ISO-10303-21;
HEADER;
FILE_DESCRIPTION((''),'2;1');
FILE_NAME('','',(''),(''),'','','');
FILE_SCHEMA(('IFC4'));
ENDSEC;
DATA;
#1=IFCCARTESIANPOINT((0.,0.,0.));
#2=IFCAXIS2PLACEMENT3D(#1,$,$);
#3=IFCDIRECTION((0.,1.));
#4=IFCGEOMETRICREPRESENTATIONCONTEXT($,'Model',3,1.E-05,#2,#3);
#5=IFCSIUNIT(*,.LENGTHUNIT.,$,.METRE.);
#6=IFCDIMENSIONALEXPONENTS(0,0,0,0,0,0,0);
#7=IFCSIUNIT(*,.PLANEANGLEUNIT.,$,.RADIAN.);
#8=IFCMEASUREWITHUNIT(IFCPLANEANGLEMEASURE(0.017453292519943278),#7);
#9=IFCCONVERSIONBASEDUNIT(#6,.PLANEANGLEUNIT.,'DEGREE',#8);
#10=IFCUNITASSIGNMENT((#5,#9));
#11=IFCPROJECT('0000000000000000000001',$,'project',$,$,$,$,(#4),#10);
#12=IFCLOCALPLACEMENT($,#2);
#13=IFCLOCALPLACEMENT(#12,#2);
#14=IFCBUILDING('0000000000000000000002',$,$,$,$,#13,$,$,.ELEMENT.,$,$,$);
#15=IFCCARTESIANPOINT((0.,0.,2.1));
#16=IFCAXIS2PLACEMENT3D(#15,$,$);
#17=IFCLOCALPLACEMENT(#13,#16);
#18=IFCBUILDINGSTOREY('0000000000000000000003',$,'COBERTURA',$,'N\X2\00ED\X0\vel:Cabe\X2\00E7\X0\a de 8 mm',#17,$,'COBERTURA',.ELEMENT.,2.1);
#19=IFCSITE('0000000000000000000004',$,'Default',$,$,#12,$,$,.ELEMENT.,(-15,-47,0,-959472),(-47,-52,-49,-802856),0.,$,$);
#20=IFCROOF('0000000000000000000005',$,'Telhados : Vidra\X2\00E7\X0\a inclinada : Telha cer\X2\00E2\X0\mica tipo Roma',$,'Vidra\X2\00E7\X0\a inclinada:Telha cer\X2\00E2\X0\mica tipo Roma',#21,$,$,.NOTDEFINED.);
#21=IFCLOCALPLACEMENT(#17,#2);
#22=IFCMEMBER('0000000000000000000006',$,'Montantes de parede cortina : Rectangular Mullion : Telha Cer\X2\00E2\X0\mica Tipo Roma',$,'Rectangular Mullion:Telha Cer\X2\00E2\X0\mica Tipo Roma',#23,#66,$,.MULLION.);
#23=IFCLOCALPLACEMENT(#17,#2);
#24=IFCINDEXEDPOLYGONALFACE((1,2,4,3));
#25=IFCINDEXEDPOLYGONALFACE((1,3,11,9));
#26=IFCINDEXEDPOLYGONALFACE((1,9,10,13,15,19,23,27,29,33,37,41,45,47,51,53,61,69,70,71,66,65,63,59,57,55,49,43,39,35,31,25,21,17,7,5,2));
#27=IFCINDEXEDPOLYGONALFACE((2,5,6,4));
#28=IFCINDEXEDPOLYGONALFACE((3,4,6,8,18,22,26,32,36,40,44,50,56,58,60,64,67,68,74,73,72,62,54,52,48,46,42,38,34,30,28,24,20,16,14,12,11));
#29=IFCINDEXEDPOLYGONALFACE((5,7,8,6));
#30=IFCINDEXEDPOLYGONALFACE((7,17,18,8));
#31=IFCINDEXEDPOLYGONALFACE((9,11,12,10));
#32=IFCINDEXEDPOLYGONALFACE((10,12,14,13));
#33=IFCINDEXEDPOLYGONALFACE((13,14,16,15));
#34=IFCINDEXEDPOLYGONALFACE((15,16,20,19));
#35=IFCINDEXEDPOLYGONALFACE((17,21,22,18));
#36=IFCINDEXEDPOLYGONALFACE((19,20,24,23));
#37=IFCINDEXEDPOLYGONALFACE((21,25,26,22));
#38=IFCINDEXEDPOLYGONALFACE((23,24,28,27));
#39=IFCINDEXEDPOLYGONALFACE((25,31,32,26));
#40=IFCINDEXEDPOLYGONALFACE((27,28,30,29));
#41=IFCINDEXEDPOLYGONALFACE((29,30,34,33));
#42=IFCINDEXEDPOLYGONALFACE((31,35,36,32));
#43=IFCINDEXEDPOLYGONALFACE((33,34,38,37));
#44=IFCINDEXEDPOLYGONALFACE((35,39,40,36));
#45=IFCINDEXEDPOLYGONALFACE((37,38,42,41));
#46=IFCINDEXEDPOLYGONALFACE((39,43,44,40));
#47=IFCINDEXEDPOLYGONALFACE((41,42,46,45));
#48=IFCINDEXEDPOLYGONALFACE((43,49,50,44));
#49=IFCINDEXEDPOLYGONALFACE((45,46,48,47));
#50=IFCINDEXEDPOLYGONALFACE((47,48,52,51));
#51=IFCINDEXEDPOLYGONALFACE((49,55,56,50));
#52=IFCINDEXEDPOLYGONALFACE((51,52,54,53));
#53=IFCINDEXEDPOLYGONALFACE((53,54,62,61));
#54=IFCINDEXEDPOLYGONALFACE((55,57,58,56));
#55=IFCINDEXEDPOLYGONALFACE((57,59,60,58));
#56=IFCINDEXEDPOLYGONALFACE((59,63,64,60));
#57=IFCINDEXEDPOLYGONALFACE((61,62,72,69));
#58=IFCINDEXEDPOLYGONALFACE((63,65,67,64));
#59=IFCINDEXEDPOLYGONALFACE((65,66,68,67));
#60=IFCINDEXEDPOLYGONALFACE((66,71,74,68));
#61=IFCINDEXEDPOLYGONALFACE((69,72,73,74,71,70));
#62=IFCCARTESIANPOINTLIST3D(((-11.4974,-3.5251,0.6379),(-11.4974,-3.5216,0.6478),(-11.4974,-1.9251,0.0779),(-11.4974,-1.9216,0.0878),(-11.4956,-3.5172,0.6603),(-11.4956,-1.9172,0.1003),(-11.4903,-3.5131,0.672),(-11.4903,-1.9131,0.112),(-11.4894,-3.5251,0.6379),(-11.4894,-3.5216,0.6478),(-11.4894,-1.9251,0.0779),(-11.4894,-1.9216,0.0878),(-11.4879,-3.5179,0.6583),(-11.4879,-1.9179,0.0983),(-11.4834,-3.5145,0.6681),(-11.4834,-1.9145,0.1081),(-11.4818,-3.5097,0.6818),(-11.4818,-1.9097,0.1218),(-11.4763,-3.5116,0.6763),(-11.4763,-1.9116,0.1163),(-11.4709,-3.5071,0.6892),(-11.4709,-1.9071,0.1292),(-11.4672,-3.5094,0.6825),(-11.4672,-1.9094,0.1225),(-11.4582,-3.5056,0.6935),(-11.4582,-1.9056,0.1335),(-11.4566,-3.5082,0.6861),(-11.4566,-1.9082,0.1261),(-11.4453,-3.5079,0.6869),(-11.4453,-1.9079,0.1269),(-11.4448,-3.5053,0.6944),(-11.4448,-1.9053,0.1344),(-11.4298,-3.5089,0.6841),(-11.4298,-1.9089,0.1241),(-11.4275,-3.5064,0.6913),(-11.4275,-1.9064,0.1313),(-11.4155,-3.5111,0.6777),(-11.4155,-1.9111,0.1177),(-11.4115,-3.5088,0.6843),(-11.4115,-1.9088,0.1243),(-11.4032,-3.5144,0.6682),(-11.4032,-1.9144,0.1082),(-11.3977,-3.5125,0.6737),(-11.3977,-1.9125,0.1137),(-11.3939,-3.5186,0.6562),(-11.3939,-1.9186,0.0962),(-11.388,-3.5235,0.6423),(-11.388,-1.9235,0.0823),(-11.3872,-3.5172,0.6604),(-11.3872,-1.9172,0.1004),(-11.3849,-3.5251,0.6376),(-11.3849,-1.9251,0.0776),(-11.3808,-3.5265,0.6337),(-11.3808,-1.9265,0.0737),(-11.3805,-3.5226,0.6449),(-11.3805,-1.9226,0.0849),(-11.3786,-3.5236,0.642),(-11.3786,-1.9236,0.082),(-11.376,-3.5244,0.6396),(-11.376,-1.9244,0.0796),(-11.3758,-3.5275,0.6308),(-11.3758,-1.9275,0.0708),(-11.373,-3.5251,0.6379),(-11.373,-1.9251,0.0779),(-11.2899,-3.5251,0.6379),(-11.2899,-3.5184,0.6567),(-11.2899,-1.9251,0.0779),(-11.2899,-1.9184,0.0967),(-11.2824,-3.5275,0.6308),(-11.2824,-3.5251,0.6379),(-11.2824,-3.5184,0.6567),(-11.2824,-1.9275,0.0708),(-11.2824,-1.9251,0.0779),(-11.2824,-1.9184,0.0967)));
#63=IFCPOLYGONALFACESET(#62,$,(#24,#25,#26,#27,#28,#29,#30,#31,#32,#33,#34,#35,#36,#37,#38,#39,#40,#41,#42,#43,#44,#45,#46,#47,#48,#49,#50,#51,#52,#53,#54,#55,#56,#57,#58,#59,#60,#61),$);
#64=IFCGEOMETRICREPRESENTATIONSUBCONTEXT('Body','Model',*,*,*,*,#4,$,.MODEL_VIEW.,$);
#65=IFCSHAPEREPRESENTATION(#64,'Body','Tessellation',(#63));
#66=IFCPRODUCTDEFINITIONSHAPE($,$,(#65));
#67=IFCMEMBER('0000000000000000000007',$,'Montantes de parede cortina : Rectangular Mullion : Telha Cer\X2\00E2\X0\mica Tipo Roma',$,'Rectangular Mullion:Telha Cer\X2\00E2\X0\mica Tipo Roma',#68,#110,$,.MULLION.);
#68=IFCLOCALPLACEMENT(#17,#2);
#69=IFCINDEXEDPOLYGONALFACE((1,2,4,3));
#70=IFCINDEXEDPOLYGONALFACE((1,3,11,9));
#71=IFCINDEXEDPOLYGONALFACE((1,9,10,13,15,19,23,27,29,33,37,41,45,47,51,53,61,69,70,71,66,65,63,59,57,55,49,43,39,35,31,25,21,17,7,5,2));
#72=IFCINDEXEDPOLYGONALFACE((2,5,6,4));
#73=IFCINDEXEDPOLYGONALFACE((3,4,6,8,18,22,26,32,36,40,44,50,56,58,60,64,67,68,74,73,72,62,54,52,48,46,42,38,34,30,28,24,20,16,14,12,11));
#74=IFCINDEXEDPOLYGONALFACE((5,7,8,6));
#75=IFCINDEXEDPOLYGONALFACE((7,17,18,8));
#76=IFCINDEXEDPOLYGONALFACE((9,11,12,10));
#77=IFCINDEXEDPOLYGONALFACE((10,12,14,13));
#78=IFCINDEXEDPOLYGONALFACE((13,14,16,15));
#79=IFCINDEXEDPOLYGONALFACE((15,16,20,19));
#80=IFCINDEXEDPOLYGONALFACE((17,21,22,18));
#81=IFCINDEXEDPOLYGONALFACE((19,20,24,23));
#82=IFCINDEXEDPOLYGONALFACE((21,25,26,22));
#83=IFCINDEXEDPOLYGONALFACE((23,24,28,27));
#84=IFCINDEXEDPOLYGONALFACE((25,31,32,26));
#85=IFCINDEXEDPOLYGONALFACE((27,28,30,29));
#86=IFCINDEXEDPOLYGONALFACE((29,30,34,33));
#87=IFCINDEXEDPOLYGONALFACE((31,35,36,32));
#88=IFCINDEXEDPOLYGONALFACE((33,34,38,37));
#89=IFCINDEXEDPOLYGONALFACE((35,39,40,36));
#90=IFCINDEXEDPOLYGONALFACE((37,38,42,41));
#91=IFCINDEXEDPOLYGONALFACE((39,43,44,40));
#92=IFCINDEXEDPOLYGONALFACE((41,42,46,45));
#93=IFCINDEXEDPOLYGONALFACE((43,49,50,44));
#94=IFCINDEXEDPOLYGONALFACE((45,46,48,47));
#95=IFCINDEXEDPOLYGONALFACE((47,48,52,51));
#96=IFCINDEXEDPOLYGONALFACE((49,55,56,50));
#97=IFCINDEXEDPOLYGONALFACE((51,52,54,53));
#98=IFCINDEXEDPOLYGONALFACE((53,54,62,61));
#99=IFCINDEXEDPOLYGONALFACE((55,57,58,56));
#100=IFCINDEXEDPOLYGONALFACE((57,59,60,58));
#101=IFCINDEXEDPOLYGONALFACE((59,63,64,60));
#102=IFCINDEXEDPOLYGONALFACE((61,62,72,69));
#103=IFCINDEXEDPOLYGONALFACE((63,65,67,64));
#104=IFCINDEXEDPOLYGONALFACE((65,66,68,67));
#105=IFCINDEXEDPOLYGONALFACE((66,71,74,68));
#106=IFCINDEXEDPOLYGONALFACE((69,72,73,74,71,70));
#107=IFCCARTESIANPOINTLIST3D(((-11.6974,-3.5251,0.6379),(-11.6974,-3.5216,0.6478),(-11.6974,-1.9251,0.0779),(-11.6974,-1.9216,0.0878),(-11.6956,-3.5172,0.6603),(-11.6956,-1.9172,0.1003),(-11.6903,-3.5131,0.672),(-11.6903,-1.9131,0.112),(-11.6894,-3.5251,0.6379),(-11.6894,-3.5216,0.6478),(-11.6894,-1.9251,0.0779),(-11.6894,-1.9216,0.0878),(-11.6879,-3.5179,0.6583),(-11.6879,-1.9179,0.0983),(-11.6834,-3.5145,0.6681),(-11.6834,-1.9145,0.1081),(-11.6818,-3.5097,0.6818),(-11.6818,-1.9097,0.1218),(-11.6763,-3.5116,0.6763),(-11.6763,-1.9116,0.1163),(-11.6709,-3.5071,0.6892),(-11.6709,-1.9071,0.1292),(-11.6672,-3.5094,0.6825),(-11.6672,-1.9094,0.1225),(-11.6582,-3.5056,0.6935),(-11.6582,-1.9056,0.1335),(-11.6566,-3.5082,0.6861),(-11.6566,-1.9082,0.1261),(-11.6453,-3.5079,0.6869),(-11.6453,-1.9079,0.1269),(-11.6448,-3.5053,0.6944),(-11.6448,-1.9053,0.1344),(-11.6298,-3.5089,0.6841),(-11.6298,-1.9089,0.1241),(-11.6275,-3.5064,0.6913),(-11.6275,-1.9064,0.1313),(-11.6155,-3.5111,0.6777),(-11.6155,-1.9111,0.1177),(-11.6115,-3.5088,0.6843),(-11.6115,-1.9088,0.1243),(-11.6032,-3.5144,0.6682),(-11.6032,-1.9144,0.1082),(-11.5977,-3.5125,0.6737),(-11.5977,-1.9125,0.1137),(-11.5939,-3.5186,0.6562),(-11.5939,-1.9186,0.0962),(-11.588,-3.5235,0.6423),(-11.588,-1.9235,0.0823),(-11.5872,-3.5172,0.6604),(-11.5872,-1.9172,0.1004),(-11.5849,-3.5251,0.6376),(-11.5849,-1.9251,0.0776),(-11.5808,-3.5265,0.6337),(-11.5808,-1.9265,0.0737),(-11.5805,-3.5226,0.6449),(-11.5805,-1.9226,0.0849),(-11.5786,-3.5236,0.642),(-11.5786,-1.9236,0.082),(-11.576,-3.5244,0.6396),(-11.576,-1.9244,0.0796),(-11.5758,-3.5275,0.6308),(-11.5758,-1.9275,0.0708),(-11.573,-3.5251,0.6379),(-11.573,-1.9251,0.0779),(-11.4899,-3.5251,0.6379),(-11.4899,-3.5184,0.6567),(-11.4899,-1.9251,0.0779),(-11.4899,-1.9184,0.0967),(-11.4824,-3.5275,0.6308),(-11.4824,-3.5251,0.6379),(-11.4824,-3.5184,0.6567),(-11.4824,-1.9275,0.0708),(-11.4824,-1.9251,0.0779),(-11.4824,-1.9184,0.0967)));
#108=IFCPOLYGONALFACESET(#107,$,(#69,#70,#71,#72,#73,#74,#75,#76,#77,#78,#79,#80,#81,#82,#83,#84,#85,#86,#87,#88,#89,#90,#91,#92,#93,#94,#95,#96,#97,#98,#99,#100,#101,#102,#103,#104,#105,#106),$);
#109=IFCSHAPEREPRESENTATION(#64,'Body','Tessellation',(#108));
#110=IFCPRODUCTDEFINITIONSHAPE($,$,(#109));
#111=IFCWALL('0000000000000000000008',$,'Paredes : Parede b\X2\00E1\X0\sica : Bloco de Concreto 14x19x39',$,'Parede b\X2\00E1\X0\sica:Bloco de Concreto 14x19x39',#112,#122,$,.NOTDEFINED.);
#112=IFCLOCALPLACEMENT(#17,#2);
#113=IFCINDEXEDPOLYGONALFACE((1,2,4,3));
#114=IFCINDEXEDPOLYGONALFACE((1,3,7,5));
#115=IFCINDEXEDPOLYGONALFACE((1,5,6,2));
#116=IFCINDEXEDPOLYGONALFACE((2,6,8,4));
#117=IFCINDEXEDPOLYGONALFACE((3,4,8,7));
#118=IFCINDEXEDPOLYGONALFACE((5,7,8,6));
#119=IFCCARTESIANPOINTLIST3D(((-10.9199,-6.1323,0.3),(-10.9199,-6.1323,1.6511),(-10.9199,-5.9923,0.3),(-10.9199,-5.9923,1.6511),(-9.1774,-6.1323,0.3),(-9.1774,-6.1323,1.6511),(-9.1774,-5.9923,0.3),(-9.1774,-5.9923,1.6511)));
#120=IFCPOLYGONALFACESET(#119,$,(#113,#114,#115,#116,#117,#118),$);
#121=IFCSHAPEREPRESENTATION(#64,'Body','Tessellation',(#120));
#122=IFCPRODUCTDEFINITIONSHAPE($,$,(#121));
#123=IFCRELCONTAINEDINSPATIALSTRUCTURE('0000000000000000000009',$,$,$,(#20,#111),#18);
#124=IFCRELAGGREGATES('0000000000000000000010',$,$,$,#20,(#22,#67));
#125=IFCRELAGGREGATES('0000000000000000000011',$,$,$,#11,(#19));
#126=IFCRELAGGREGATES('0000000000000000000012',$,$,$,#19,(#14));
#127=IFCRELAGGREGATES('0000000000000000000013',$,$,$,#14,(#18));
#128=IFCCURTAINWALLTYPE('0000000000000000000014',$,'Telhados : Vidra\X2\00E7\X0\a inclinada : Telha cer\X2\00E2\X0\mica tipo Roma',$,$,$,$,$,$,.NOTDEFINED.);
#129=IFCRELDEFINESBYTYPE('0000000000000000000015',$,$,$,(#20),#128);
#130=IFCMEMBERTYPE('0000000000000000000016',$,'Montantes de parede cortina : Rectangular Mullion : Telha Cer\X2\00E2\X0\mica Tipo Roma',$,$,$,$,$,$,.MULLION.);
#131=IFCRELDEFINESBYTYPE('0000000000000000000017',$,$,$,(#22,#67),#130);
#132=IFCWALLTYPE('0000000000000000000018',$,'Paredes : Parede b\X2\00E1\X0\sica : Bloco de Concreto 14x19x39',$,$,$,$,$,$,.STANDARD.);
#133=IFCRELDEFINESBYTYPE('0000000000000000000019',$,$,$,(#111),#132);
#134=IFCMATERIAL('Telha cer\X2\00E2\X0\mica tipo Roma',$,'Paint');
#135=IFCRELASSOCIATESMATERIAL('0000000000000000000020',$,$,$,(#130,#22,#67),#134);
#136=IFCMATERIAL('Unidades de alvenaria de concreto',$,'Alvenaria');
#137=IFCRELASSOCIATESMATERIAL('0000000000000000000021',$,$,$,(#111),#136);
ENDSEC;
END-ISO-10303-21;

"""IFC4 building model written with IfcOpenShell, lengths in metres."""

from ifc_helpers import new_model, entity, si_unit, converted_unit, direction, frame, origin, place, context, subcontext, project, spatial, line, arc, indexed_curve, outline, extrude, source, transform, mapped, material, type_object, type_shapes, element, aggregate, save


model = new_model("IFC4")

# Units and contexts
model_context = context("Model", 3, precision=1e-05, world=origin(), true_north=direction((0.0, 1.0)))
body_context = subcontext(model_context, "Body", "Model", "MODEL_VIEW")
ifc_project = project(units=[si_unit("LENGTHUNIT", "METRE"), converted_unit("PLANEANGLEUNIT", "DEGREE", entity("IfcPlaneAngleMeasure", 0.017453292519943278), si_unit("PLANEANGLEUNIT", "RADIAN"), dimensions=[0, 0, 0, 0, 0, 0, 0])], contexts=[model_context])

# Site, building, storey
site_placement = place(None, origin())
site = spatial("IfcSite", under=ifc_project, at=site_placement, Name="Default", CompositionType="ELEMENT", RefLatitude=(-15, -47, 0, -959472), RefLongitude=(-47, -52, -49, -802856), RefElevation=0.0)
building_placement = place(site_placement, origin())
building = spatial("IfcBuilding", under=site, at=building_placement, CompositionType="ELEMENT")
storey_placement = place(building_placement, frame((0.0, 0.0, 2.1)))
storey = spatial("IfcBuildingStorey", under=building, at=storey_placement, Name="COBERTURA", ObjectType="Nível:Cabeça de 8 mm", LongName="COBERTURA", CompositionType="ELEMENT", Elevation=2.1)

# Roof, members
curtain_wall_type_1 = type_object("IfcCurtainWallType", Name="Telhados : Vidraça inclinada : Telha cerâmica tipo Roma", PredefinedType="NOTDEFINED")
roof_1_placement = place(storey_placement, frame((0.0, 0.0, -2.1)))
roof_1 = element("IfcRoof", 1, at=roof_1_placement, inside=storey, type_object=curtain_wall_type_1, Name="Telhados : Vidraça inclinada : Telha cerâmica tipo Roma", ObjectType="Vidraça inclinada:Telha cerâmica tipo Roma", PredefinedType="NOTDEFINED")
ifc_material_1 = material(Name="Telha cerâmica tipo Roma", Category="Paint")
member_type_1 = type_object("IfcMemberType", Name="Montantes de parede cortina : Rectangular Mullion : Telha Cerâmica Tipo Roma", PredefinedType="MULLION", material=ifc_material_1)
shared_shape_1 = source(origin(), body_context, "Body", "SweptSolid", [
    extrude(outline(indexed_curve([(0.0114, -0.0188), (0.1048, -0.0188), (0.1048, -0.0113), (0.1048, 0.0087), (0.0973, 0.0087), (0.0973, -0.0113), (0.0142, -0.0113), (0.0098, -0.0083), (0.0067, -0.0038), (-0.017, 0.0327), (-0.0576, 0.0486), (-0.0946, 0.0352), (-0.1102, -0.0008), (-0.1102, -0.0113), (-0.1022, -0.0113), (-0.1022, -0.0008), (-0.0891, 0.0294), (-0.0581, 0.0406), (-0.0218, 0.0263), (-0.0008, -0.0066), (0.0042, -0.0138)], segments=[line(1, 2, 3, 4, 5, 6, 7), arc(7, 8, 9), arc(9, 10, 11), arc(11, 12, 13), line(13, 14, 15, 16), arc(16, 17, 18), arc(18, 19, 20), arc(20, 21, 1)], self_intersect=False)), frame((-0.0027, -0.0938, -4.3552), z_axis=(0.0, 0.0, 1.0), x_axis=(-1.0, 0.0, 0.0)), (0.0, 0.0, 1.0), 1.6952),
])
type_shapes(member_type_1, [shared_shape_1])
member_1_placement = place(roof_1_placement, frame((-11.3899, -6.063, 3.5387), z_axis=(0.0, -0.943858, 0.33035), x_axis=(-1.0, 0.0, 0.0)))
member_1 = element("IfcMember", 2, at=member_1_placement, type_object=member_type_1, material=ifc_material_1, Name="Montantes de parede cortina : Rectangular Mullion : Telha Cerâmica Tipo Roma", ObjectType="Rectangular Mullion:Telha Cerâmica Tipo Roma", PredefinedType="MULLION", context=body_context, shape_type="MappedRepresentation", body=[
    mapped(shared_shape_1, transform((0.0, 0.0, 0.0), scale=1.0)),
])
member_2_placement = place(roof_1_placement, frame((-11.5899, -6.063, 3.5387), z_axis=(0.0, -0.943858, 0.33035), x_axis=(-1.0, 0.0, 0.0)))
member_2 = element("IfcMember", 3, at=member_2_placement, type_object=member_type_1, material=ifc_material_1, Name="Montantes de parede cortina : Rectangular Mullion : Telha Cerâmica Tipo Roma", ObjectType="Rectangular Mullion:Telha Cerâmica Tipo Roma", PredefinedType="MULLION", context=body_context, shape_type="MappedRepresentation", body=[
    mapped(shared_shape_1, transform((0.0, 0.0, 0.0), scale=1.0)),
])
aggregate(roof_1, [member_1, member_2])

# Wall
ifc_material_2 = material(Name="Unidades de alvenaria de concreto", Category="Alvenaria")
wall_type = type_object("IfcWallType", Name="Paredes : Parede básica : Bloco de Concreto 14x19x39", PredefinedType="STANDARD")
wall_placement = place(storey_placement, frame((-10.9199, -6.0623, 0.3)))
element("IfcWall", 4, at=wall_placement, inside=storey, type_object=wall_type, material=ifc_material_2, Name="Paredes : Parede básica : Bloco de Concreto 14x19x39", ObjectType="Parede básica:Bloco de Concreto 14x19x39", PredefinedType="NOTDEFINED", context=body_context, shape_type="SweptSolid", body=[
    extrude(outline(indexed_curve([(1.7425, 0.07), (0.0, 0.07), (0.0, -0.07), (1.7425, -0.07), (1.7425, 0.07)], self_intersect=False)), origin(), (0.0, 0.0, 1.0), 1.3511),
])

save(model, "model.ifc")
